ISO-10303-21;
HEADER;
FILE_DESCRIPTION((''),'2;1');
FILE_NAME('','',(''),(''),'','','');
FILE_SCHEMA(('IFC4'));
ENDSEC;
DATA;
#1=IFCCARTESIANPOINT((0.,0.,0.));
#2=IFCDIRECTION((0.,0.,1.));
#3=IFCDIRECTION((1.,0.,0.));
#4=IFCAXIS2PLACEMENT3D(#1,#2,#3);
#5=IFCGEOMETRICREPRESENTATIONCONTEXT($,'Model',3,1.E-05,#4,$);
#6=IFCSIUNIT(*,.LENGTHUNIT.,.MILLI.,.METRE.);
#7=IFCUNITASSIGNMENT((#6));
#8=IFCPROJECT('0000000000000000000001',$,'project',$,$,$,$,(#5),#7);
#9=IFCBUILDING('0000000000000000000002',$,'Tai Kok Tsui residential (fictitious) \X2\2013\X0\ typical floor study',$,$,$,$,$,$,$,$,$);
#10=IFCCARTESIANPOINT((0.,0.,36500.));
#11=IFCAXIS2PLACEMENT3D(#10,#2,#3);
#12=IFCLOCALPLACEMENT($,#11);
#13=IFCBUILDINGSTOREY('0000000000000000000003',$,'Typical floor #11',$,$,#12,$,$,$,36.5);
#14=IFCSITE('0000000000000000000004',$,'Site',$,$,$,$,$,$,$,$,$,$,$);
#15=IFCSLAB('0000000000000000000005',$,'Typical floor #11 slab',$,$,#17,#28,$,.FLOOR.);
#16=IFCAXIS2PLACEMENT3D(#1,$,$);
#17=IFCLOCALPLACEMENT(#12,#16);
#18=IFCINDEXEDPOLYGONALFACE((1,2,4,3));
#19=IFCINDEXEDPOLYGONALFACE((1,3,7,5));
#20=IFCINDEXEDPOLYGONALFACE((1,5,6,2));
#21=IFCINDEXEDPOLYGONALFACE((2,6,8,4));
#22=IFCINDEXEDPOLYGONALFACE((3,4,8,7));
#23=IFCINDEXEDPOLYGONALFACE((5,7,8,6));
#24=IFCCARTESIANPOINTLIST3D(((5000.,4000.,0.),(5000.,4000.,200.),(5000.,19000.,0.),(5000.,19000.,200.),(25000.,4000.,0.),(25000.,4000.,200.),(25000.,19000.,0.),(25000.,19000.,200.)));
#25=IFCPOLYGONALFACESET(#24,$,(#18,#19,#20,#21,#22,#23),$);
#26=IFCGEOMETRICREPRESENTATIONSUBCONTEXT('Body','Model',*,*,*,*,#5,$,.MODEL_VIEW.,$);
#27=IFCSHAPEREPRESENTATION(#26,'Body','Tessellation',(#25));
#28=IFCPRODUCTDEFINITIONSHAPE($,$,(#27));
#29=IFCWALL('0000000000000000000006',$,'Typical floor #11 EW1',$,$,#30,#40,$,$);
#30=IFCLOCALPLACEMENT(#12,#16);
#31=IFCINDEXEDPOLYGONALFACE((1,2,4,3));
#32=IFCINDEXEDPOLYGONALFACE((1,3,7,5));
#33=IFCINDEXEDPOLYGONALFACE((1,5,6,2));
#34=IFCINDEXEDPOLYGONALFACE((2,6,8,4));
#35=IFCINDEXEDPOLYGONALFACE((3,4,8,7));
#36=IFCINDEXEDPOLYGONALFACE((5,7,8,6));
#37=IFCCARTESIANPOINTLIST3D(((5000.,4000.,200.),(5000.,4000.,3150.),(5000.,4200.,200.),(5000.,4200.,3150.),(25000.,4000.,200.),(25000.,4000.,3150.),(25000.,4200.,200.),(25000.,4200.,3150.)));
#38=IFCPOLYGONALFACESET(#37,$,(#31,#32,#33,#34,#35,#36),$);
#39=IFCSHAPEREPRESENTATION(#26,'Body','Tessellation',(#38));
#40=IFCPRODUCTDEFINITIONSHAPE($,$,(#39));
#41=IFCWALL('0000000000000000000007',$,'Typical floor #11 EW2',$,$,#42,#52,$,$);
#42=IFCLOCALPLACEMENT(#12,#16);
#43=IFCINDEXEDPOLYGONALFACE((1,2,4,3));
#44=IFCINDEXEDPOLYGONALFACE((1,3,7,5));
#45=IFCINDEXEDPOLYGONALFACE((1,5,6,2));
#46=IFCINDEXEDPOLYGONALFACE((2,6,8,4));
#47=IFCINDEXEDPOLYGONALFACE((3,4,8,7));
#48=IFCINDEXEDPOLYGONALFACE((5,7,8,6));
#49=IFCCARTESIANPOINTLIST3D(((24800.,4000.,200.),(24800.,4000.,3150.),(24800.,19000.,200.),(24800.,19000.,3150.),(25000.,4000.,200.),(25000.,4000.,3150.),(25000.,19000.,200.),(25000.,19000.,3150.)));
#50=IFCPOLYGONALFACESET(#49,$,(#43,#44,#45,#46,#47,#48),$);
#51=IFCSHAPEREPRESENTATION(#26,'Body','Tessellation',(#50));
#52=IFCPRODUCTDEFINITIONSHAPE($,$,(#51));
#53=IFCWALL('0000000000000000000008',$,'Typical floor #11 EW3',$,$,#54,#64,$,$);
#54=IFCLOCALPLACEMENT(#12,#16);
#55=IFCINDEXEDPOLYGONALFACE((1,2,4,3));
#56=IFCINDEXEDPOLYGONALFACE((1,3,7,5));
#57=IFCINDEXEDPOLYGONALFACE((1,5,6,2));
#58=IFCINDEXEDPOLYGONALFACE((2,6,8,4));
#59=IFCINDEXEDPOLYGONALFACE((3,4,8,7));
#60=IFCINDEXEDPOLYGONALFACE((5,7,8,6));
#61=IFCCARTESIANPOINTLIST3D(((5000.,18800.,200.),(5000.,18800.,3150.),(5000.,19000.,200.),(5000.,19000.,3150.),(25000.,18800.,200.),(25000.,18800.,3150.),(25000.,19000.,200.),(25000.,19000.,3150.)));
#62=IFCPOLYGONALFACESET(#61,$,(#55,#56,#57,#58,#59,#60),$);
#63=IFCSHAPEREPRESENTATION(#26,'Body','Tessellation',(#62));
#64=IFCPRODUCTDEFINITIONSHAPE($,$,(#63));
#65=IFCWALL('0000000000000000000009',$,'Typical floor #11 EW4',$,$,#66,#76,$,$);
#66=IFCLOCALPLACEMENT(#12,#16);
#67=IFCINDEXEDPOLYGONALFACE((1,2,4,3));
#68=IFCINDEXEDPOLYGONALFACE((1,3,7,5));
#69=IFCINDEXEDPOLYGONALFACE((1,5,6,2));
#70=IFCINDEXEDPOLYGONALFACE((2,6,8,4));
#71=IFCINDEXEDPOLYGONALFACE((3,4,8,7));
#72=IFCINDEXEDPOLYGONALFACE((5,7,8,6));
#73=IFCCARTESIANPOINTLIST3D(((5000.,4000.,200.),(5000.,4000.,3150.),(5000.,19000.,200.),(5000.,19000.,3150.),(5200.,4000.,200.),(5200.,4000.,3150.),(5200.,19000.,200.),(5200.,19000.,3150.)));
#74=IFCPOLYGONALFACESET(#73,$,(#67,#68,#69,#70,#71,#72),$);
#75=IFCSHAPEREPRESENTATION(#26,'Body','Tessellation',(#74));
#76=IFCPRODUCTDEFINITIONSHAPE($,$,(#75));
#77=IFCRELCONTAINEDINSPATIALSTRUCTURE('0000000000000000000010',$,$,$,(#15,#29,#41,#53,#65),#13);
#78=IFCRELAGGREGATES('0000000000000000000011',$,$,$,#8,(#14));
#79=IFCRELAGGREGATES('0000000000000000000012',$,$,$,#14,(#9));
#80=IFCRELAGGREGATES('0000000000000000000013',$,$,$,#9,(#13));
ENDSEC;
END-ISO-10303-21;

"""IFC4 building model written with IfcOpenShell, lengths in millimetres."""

from ifc_helpers import new_model, si_unit, frame, origin_with_axes, place, context, subcontext, project, spatial, indexed_curve, outline, extrude, element, save


model = new_model("IFC4")

# Units and contexts
model_context = context("Model", 3, precision=1e-05, world=origin_with_axes())
body_context = subcontext(model_context, "Body", "Model", "MODEL_VIEW")
ifc_project = project(units=[si_unit("LENGTHUNIT", "METRE", prefix="MILLI")], contexts=[model_context])

# Site, building, storey
site = spatial("IfcSite", under=ifc_project, Name="Site")
building = spatial("IfcBuilding", under=site, Name="Tai Kok Tsui residential (fictitious) – typical floor study")
storey_placement = place(None, frame((0.0, 0.0, 36500.0), z_axis=(0.0, 0.0, 1.0), x_axis=(1.0, 0.0, 0.0)))
storey = spatial("IfcBuildingStorey", under=building, at=storey_placement, Name="Typical floor #11", Elevation=36.5)

# Slab
slab_placement = place(storey_placement, origin_with_axes())
element("IfcSlab", 1, at=slab_placement, inside=storey, Name="Typical floor #11 slab", PredefinedType="FLOOR", context=body_context, shape_type="SweptSolid", body=[
    extrude(outline(indexed_curve([(5000.0, 4000.0), (25000.0, 4000.0), (25000.0, 19000.0), (5000.0, 19000.0)])), None, (0.0, 0.0, 1.0), 200.0),
])

# Walls
wall_1_placement = place(storey_placement, frame((5000.0, 4000.0, 200.0), z_axis=(0.0, 0.0, 1.0), x_axis=(1.0, 0.0, 0.0)))
element("IfcWall", 2, at=wall_1_placement, inside=storey, Name="Typical floor #11 EW1", context=body_context, shape_type="SweptSolid", body=[
    extrude(outline(indexed_curve([(0.0, 0.0), (0.0, 200.0), (20000.0, 200.0), (20000.0, 0.0), (0.0, 0.0)], self_intersect=False)), origin_with_axes(), (0.0, 0.0, 1.0), 2950.0),
])
wall_2_placement = place(storey_placement, frame((25000.0, 4000.0, 200.0), z_axis=(0.0, 0.0, 1.0), x_axis=(0.0, 1.0, 0.0)))
element("IfcWall", 3, at=wall_2_placement, inside=storey, Name="Typical floor #11 EW2", context=body_context, shape_type="SweptSolid", body=[
    extrude(outline(indexed_curve([(0.0, 0.0), (0.0, 200.0), (15000.0, 200.0), (15000.0, 0.0), (0.0, 0.0)], self_intersect=False)), origin_with_axes(), (0.0, 0.0, 1.0), 2950.0),
])
wall_3_placement = place(storey_placement, frame((25000.0, 19000.0, 200.0), z_axis=(0.0, 0.0, 1.0), x_axis=(-1.0, 0.0, 0.0)))
element("IfcWall", 4, at=wall_3_placement, inside=storey, Name="Typical floor #11 EW3", context=body_context, shape_type="SweptSolid", body=[
    extrude(outline(indexed_curve([(0.0, 0.0), (0.0, 200.0), (20000.0, 200.0), (20000.0, 0.0), (0.0, 0.0)], self_intersect=False)), origin_with_axes(), (0.0, 0.0, 1.0), 2950.0),
])
wall_4_placement = place(storey_placement, frame((5000.0, 19000.0, 200.0), z_axis=(0.0, 0.0, 1.0), x_axis=(0.0, -1.0, 0.0)))
element("IfcWall", 5, at=wall_4_placement, inside=storey, Name="Typical floor #11 EW4", context=body_context, shape_type="SweptSolid", body=[
    extrude(outline(indexed_curve([(0.0, 0.0), (0.0, 200.0), (15000.0, 200.0), (15000.0, 0.0), (0.0, 0.0)], self_intersect=False)), origin_with_axes(), (0.0, 0.0, 1.0), 2950.0),
])

save(model, "model.ifc")
